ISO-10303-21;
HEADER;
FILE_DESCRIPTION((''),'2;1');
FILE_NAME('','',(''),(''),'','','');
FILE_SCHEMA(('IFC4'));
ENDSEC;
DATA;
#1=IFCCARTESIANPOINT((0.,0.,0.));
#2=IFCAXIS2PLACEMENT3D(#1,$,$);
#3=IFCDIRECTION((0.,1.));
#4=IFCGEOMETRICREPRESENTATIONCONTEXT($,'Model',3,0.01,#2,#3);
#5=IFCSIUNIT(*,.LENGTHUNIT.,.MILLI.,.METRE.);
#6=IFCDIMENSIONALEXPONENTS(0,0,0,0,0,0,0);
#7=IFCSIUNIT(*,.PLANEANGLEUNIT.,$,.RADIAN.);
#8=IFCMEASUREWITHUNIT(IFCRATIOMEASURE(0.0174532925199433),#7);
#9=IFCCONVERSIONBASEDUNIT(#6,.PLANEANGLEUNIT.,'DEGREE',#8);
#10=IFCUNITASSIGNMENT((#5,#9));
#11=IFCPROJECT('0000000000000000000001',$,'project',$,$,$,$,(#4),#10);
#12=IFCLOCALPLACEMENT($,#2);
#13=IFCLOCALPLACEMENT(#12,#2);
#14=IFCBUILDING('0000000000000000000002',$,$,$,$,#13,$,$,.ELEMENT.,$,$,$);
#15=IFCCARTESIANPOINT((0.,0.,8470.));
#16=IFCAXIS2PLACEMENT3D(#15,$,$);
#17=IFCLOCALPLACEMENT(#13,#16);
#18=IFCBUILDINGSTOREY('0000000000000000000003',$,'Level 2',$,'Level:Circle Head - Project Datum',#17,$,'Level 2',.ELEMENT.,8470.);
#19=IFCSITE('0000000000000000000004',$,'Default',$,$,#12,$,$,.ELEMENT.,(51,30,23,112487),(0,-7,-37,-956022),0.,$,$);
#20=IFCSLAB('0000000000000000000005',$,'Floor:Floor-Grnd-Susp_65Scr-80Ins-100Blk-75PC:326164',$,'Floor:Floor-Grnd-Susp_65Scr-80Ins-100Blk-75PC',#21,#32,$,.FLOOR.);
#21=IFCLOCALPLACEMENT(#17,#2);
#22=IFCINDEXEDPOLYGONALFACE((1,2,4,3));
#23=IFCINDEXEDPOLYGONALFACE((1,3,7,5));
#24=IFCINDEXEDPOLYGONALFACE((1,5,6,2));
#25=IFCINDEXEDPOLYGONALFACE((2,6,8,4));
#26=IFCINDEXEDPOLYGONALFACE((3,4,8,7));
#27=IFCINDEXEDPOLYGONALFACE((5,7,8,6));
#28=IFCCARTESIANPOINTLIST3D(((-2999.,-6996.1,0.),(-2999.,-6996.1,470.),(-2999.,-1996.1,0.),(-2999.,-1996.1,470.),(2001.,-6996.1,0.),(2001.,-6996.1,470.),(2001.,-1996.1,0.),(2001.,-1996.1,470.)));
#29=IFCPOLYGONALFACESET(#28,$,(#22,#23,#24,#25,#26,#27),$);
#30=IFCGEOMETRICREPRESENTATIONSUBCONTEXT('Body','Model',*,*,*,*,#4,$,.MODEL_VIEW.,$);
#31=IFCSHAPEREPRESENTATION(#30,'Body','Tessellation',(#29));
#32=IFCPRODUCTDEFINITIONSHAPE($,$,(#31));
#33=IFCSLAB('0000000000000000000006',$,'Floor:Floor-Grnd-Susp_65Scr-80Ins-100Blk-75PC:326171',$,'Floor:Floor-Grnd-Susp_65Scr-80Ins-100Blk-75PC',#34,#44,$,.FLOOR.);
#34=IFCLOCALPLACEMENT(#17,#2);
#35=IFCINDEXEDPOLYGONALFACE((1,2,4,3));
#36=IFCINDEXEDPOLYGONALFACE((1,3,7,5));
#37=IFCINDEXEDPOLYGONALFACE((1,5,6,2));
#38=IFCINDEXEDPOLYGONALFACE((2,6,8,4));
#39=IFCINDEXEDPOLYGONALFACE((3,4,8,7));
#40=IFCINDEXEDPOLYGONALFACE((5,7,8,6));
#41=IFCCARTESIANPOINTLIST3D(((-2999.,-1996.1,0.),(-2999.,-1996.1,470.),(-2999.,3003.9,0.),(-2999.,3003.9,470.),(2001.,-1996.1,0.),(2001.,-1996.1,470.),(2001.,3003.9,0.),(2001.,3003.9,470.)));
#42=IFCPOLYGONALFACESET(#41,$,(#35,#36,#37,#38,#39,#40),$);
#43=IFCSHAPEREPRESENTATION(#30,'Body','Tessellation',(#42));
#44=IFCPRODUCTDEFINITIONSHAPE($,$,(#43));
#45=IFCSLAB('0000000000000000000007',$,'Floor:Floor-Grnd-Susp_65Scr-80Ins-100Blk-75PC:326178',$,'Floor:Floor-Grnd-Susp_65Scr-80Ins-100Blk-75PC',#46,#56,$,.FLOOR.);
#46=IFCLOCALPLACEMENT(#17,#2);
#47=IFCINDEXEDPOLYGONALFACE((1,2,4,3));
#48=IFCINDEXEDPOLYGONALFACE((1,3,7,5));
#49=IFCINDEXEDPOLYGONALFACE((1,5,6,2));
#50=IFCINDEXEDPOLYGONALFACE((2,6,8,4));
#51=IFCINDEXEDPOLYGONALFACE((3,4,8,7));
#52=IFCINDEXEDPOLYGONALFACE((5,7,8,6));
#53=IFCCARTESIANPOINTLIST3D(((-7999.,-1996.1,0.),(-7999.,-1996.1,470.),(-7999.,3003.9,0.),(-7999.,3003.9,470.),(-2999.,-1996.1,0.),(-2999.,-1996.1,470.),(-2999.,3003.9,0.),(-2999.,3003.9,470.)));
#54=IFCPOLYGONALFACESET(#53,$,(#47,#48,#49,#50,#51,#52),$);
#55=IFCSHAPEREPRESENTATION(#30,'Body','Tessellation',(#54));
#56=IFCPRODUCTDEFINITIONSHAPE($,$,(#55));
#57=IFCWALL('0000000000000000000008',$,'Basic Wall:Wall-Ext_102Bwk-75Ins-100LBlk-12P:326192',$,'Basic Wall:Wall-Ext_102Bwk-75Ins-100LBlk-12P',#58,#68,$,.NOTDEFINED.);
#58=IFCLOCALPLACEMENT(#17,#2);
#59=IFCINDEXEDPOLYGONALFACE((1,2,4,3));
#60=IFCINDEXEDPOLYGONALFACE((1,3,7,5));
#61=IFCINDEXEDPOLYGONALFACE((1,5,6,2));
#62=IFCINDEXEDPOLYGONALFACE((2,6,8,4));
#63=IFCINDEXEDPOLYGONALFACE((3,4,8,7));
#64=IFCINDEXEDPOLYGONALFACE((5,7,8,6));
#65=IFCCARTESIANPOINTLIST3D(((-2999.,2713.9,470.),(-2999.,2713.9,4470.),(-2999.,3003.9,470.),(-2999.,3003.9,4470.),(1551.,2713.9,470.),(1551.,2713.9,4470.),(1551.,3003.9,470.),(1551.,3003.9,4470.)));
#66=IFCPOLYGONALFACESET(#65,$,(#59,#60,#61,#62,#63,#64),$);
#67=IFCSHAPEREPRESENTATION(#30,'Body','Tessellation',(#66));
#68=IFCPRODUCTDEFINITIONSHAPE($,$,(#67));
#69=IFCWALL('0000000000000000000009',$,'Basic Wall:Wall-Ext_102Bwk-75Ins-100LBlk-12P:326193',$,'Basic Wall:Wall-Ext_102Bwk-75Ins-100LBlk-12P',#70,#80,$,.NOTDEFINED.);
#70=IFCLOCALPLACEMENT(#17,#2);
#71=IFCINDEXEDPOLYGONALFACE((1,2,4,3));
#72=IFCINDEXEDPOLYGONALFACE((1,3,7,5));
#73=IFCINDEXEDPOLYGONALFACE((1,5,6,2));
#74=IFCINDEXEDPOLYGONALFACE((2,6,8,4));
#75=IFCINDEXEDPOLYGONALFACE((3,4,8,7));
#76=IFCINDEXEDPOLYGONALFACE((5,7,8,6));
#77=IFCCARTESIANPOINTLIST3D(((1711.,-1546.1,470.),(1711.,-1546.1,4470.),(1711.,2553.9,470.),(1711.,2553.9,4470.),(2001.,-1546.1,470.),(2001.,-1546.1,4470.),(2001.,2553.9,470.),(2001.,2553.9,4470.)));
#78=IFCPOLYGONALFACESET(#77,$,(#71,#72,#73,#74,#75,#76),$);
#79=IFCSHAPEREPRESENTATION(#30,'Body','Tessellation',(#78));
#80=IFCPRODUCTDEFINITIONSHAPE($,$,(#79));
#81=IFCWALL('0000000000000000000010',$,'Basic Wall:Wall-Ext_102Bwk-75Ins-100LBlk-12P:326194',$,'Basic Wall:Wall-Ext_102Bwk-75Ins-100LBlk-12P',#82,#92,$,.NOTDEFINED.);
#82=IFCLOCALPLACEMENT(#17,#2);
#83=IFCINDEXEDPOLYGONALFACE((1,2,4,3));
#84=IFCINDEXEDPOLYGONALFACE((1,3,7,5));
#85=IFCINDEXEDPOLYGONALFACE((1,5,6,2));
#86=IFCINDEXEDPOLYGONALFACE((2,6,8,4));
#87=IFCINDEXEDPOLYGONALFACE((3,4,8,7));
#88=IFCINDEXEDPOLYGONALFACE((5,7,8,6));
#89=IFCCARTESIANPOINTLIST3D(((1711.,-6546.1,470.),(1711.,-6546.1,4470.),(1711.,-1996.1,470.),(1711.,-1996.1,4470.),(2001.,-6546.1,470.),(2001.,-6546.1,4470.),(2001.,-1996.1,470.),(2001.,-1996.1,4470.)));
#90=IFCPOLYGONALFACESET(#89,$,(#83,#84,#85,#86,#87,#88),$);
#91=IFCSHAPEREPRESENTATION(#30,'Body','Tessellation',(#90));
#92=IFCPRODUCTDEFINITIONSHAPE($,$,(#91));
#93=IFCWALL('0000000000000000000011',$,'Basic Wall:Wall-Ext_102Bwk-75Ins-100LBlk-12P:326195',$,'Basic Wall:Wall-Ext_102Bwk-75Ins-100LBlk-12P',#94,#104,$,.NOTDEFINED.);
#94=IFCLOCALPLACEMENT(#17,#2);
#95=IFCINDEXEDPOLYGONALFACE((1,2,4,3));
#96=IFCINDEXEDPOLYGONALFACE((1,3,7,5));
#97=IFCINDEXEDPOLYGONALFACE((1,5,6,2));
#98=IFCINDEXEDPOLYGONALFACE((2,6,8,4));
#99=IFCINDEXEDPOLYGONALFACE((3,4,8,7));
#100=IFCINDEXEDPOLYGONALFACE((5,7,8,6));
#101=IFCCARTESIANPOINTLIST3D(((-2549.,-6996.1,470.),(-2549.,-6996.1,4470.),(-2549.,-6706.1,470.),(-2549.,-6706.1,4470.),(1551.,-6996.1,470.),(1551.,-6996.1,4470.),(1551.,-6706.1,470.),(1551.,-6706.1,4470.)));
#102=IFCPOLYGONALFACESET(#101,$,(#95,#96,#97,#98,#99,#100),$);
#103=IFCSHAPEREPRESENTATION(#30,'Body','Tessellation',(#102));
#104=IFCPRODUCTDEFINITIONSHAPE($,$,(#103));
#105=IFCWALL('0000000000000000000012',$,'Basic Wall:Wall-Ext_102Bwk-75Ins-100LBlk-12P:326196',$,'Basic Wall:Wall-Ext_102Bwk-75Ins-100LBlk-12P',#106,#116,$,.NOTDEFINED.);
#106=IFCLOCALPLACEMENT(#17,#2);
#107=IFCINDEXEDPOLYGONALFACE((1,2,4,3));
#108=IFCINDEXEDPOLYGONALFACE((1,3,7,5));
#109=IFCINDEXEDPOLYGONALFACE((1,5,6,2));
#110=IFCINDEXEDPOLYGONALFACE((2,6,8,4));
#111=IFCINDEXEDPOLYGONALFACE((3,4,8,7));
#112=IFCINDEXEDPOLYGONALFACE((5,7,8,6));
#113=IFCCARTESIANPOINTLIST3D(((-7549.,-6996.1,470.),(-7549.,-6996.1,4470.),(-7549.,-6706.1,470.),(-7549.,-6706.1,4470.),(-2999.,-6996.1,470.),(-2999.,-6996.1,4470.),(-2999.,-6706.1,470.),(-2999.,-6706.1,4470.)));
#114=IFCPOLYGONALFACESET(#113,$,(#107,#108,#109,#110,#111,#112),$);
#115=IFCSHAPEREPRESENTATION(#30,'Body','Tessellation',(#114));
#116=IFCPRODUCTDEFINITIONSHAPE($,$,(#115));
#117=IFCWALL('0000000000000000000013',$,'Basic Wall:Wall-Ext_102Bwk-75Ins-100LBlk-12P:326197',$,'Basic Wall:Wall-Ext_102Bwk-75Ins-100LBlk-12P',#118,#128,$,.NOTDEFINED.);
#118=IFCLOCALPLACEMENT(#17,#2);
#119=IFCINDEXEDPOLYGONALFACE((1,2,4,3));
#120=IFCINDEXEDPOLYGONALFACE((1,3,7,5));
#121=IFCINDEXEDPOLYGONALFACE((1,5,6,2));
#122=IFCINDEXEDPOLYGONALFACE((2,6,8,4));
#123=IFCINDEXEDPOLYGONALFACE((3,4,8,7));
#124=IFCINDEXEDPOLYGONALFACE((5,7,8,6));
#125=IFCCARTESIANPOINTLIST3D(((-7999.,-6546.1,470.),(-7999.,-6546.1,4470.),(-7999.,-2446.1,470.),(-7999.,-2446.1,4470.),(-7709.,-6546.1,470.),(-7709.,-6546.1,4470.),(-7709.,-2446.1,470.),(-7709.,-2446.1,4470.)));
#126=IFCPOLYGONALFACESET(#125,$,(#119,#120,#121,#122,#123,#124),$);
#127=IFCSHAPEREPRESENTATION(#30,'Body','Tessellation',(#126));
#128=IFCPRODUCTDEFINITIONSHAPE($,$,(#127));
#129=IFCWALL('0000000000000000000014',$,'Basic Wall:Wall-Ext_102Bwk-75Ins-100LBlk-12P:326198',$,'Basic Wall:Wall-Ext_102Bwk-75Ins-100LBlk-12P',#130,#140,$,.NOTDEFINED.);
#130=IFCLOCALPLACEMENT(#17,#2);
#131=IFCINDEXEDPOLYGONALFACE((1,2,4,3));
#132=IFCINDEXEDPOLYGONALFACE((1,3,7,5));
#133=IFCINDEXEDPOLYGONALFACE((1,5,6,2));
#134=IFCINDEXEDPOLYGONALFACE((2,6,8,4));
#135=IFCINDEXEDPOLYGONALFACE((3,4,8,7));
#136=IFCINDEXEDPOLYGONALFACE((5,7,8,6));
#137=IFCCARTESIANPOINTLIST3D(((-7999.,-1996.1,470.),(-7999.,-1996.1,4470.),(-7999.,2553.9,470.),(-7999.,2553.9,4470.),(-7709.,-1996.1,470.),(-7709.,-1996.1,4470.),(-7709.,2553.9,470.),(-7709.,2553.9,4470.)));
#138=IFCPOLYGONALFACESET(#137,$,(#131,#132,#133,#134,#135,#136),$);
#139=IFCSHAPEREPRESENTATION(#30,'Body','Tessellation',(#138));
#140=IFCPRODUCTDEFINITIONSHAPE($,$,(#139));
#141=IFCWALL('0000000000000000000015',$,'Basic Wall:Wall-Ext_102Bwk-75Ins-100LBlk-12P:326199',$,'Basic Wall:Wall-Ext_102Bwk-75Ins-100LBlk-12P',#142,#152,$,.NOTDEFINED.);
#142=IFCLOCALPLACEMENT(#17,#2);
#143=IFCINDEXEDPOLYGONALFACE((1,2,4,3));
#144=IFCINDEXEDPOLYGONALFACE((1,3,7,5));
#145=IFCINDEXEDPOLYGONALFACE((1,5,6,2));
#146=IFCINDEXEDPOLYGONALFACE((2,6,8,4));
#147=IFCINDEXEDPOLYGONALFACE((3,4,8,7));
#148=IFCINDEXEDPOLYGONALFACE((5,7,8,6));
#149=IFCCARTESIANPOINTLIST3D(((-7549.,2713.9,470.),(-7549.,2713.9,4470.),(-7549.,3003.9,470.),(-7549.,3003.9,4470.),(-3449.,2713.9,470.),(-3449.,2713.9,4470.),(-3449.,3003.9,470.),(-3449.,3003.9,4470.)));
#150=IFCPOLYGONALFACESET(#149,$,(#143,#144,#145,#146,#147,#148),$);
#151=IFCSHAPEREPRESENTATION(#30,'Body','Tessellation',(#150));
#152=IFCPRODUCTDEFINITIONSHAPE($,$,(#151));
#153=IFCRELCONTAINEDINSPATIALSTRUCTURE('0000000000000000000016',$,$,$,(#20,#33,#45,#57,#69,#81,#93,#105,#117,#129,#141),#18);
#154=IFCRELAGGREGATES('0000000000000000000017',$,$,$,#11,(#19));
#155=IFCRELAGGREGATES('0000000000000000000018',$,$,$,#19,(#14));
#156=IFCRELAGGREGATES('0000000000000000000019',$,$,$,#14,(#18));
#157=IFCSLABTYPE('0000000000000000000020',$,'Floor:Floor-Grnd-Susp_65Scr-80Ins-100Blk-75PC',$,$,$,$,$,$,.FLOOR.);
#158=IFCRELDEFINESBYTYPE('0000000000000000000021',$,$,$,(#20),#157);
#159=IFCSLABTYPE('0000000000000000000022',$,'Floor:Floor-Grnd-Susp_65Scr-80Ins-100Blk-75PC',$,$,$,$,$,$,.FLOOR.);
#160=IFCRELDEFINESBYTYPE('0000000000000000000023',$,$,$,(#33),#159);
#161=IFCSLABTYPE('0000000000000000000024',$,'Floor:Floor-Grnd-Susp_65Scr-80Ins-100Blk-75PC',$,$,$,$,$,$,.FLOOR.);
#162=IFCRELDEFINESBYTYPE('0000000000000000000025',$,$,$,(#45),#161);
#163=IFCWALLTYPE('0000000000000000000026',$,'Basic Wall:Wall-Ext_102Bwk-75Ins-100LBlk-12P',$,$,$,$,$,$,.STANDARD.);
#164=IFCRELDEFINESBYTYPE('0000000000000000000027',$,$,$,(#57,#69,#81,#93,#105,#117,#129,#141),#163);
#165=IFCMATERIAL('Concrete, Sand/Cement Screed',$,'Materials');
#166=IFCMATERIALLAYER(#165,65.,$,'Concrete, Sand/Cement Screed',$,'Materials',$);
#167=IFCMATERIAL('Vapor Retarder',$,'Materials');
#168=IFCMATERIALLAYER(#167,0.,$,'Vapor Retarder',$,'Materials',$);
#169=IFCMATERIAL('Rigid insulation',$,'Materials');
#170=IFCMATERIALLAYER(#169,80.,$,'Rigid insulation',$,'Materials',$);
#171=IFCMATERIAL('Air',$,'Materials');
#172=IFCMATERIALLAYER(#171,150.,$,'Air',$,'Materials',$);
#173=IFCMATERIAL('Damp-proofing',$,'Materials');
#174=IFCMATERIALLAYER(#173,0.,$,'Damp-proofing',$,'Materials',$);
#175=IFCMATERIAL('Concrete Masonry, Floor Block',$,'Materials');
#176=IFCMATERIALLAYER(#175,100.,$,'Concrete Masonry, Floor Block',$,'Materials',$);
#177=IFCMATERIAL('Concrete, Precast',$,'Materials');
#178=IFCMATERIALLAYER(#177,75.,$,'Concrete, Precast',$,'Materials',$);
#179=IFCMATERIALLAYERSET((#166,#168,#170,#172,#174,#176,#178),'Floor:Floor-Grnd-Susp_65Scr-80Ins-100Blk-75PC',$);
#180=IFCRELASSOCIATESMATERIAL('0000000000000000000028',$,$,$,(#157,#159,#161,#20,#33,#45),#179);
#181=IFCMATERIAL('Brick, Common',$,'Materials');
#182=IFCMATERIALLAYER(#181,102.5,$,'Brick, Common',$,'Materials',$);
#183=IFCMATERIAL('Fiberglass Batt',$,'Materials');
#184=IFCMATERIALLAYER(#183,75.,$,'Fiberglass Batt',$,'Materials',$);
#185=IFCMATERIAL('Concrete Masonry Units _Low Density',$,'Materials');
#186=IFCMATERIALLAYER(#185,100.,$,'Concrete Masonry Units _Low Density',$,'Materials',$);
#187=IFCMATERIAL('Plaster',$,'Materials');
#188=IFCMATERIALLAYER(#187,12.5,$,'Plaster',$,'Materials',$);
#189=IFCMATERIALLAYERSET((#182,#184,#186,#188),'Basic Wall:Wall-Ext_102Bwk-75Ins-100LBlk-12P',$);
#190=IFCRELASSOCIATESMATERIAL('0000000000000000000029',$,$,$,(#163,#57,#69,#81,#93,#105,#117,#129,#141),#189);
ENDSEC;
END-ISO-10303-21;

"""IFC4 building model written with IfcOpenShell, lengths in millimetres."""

from ifc_helpers import new_model, entity, si_unit, converted_unit, direction, frame, frame_2d, origin, origin_2d_with_axis, place, context, subcontext, project, spatial, rectangle, extrude, material, layer, layer_set, layer_usage, type_object, element, save


model = new_model("IFC4")

# Units and contexts
model_context = context("Model", 3, precision=0.01, world=origin(), true_north=direction((0.0, 1.0)))
body_context = subcontext(model_context, "Body", "Model", "MODEL_VIEW")
ifc_project = project(units=[si_unit("LENGTHUNIT", "METRE", prefix="MILLI"), converted_unit("PLANEANGLEUNIT", "DEGREE", entity("IfcRatioMeasure", 0.0174532925199433), si_unit("PLANEANGLEUNIT", "RADIAN"), dimensions=[0, 0, 0, 0, 0, 0, 0])], contexts=[model_context])

# Site, building, storey
site_placement = place(None, origin())
site = spatial("IfcSite", under=ifc_project, at=site_placement, Name="Default", CompositionType="ELEMENT", RefLatitude=(51, 30, 23, 112487), RefLongitude=(0, -7, -37, -956022), RefElevation=0.0)
building_placement = place(site_placement, origin())
building = spatial("IfcBuilding", under=site, at=building_placement, CompositionType="ELEMENT")
storey_placement = place(building_placement, frame((0.0, 0.0, 8470.0)))
storey = spatial("IfcBuildingStorey", under=building, at=storey_placement, Name="Level 2", ObjectType="Level:Circle Head - Project Datum", LongName="Level 2", CompositionType="ELEMENT", Elevation=8470.0)

# Slabs
ifc_material_1 = material(Name="Concrete, Sand/Cement Screed", Category="Materials")
ifc_layer_1 = layer(ifc_material_1, 65.0, Name="Concrete, Sand/Cement Screed", Category="Materials")
ifc_material_2 = material(Name="Vapor Retarder", Category="Materials")
ifc_layer_2 = layer(ifc_material_2, 0.0, Name="Vapor Retarder", Category="Materials")
ifc_material_3 = material(Name="Rigid insulation", Category="Materials")
ifc_layer_3 = layer(ifc_material_3, 80.0, Name="Rigid insulation", Category="Materials")
ifc_material_4 = material(Name="Air", Category="Materials")
ifc_layer_4 = layer(ifc_material_4, 150.0, Name="Air", Category="Materials")
ifc_material_5 = material(Name="Damp-proofing", Category="Materials")
ifc_layer_5 = layer(ifc_material_5, 0.0, Name="Damp-proofing", Category="Materials")
ifc_material_6 = material(Name="Concrete Masonry, Floor Block", Category="Materials")
ifc_layer_6 = layer(ifc_material_6, 100.0, Name="Concrete Masonry, Floor Block", Category="Materials")
ifc_material_7 = material(Name="Concrete, Precast", Category="Materials")
ifc_layer_7 = layer(ifc_material_7, 75.0, Name="Concrete, Precast", Category="Materials")
ifc_layer_set_1 = layer_set([ifc_layer_1, ifc_layer_2, ifc_layer_3, ifc_layer_4, ifc_layer_5, ifc_layer_6, ifc_layer_7], Name="Floor:Floor-Grnd-Susp_65Scr-80Ins-100Blk-75PC")
ifc_layer_usage_1 = layer_usage(ifc_layer_set_1, "AXIS3", "POSITIVE", 0.0)
slab_type_1 = type_object("IfcSlabType", Name="Floor:Floor-Grnd-Susp_65Scr-80Ins-100Blk-75PC", PredefinedType="FLOOR", material=ifc_layer_set_1)
slab_1_placement = place(storey_placement, origin())
element("IfcSlab", 1, at=slab_1_placement, inside=storey, type_object=slab_type_1, material=ifc_layer_usage_1, Name="Floor:Floor-Grnd-Susp_65Scr-80Ins-100Blk-75PC:326164", ObjectType="Floor:Floor-Grnd-Susp_65Scr-80Ins-100Blk-75PC", PredefinedType="FLOOR", context=body_context, shape_type="SweptSolid", body=[
    extrude(rectangle(XDim=5000.0, YDim=5000.0, at=frame_2d((0.0, 0.0), x_axis=(1.0, 0.0))), frame((-499.0, -4496.1, 470.0), z_axis=(0.0, 0.0, -1.0), x_axis=(0.0, 1.0, 0.0)), (0.0, 0.0, 1.0), 470.0),
])
ifc_layer_usage_2 = layer_usage(ifc_layer_set_1, "AXIS3", "POSITIVE", 0.0)
slab_type_2 = type_object("IfcSlabType", Name="Floor:Floor-Grnd-Susp_65Scr-80Ins-100Blk-75PC", PredefinedType="FLOOR", material=ifc_layer_set_1)
slab_2_placement = place(storey_placement, origin())
element("IfcSlab", 2, at=slab_2_placement, inside=storey, type_object=slab_type_2, material=ifc_layer_usage_2, Name="Floor:Floor-Grnd-Susp_65Scr-80Ins-100Blk-75PC:326171", ObjectType="Floor:Floor-Grnd-Susp_65Scr-80Ins-100Blk-75PC", PredefinedType="FLOOR", context=body_context, shape_type="SweptSolid", body=[
    extrude(rectangle(XDim=5000.0, YDim=5000.0, at=origin_2d_with_axis()), frame((-499.0, 503.9, 470.0), z_axis=(0.0, 0.0, -1.0), x_axis=(0.0, 1.0, 0.0)), (0.0, 0.0, 1.0), 470.0),
])
ifc_layer_usage_3 = layer_usage(ifc_layer_set_1, "AXIS3", "POSITIVE", 0.0)
slab_type_3 = type_object("IfcSlabType", Name="Floor:Floor-Grnd-Susp_65Scr-80Ins-100Blk-75PC", PredefinedType="FLOOR", material=ifc_layer_set_1)
slab_3_placement = place(storey_placement, origin())
element("IfcSlab", 3, at=slab_3_placement, inside=storey, type_object=slab_type_3, material=ifc_layer_usage_3, Name="Floor:Floor-Grnd-Susp_65Scr-80Ins-100Blk-75PC:326178", ObjectType="Floor:Floor-Grnd-Susp_65Scr-80Ins-100Blk-75PC", PredefinedType="FLOOR", context=body_context, shape_type="SweptSolid", body=[
    extrude(rectangle(XDim=5000.0, YDim=5000.0, at=origin_2d_with_axis()), frame((-5499.0, 503.9, 470.0), z_axis=(0.0, 0.0, -1.0), x_axis=(0.0, 1.0, 0.0)), (0.0, 0.0, 1.0), 470.0),
])

# Walls
ifc_material_8 = material(Name="Brick, Common", Category="Materials")
ifc_layer_8 = layer(ifc_material_8, 102.5, Name="Brick, Common", Category="Materials")
ifc_material_9 = material(Name="Fiberglass Batt", Category="Materials")
ifc_layer_9 = layer(ifc_material_9, 75.0, Name="Fiberglass Batt", Category="Materials")
ifc_material_10 = material(Name="Concrete Masonry Units _Low Density", Category="Materials")
ifc_layer_10 = layer(ifc_material_10, 100.0, Name="Concrete Masonry Units _Low Density", Category="Materials")
ifc_material_11 = material(Name="Plaster", Category="Materials")
ifc_layer_11 = layer(ifc_material_11, 12.5, Name="Plaster", Category="Materials")
ifc_layer_set_2 = layer_set([ifc_layer_8, ifc_layer_9, ifc_layer_10, ifc_layer_11], Name="Basic Wall:Wall-Ext_102Bwk-75Ins-100LBlk-12P")
ifc_layer_usage_4 = layer_usage(ifc_layer_set_2, "AXIS2", "NEGATIVE", 145.0)
wall_type = type_object("IfcWallType", Name="Basic Wall:Wall-Ext_102Bwk-75Ins-100LBlk-12P", PredefinedType="STANDARD", material=ifc_layer_set_2)
wall_1_placement = place(storey_placement, frame((-2999.0, 2858.9, 470.0)))
element("IfcWall", 4, at=wall_1_placement, inside=storey, type_object=wall_type, material=ifc_layer_usage_4, Name="Basic Wall:Wall-Ext_102Bwk-75Ins-100LBlk-12P:326192", ObjectType="Basic Wall:Wall-Ext_102Bwk-75Ins-100LBlk-12P", PredefinedType="NOTDEFINED", context=body_context, shape_type="SweptSolid", body=[
    extrude(rectangle(XDim=4550.0, YDim=290.0, at=frame_2d((2275.0, 0.0), x_axis=(-1.0, 0.0))), origin(), (0.0, 0.0, 1.0), 4000.0),
])
ifc_layer_usage_5 = layer_usage(ifc_layer_set_2, "AXIS2", "NEGATIVE", 145.0)
wall_2_placement = place(storey_placement, frame((1856.0, 2553.9, 470.0), z_axis=(0.0, 0.0, 1.0), x_axis=(0.0, -1.0, 0.0)))
element("IfcWall", 5, at=wall_2_placement, inside=storey, type_object=wall_type, material=ifc_layer_usage_5, Name="Basic Wall:Wall-Ext_102Bwk-75Ins-100LBlk-12P:326193", ObjectType="Basic Wall:Wall-Ext_102Bwk-75Ins-100LBlk-12P", PredefinedType="NOTDEFINED", context=body_context, shape_type="SweptSolid", body=[
    extrude(rectangle(XDim=4100.0, YDim=290.0, at=frame_2d((2050.0, 0.0), x_axis=(-1.0, 0.0))), origin(), (0.0, 0.0, 1.0), 4000.0),
])
ifc_layer_usage_6 = layer_usage(ifc_layer_set_2, "AXIS2", "NEGATIVE", 145.0)
wall_3_placement = place(storey_placement, frame((1856.0, -1996.1, 470.0), z_axis=(0.0, 0.0, 1.0), x_axis=(0.0, -1.0, 0.0)))
element("IfcWall", 6, at=wall_3_placement, inside=storey, type_object=wall_type, material=ifc_layer_usage_6, Name="Basic Wall:Wall-Ext_102Bwk-75Ins-100LBlk-12P:326194", ObjectType="Basic Wall:Wall-Ext_102Bwk-75Ins-100LBlk-12P", PredefinedType="NOTDEFINED", context=body_context, shape_type="SweptSolid", body=[
    extrude(rectangle(XDim=4550.0, YDim=290.0, at=frame_2d((2275.0, 0.0), x_axis=(-1.0, 0.0))), origin(), (0.0, 0.0, 1.0), 4000.0),
])
ifc_layer_usage_7 = layer_usage(ifc_layer_set_2, "AXIS2", "NEGATIVE", 145.0)
wall_4_placement = place(storey_placement, frame((1551.0, -6851.1, 470.0), z_axis=(0.0, 0.0, 1.0), x_axis=(-1.0, 0.0, 0.0)))
element("IfcWall", 7, at=wall_4_placement, inside=storey, type_object=wall_type, material=ifc_layer_usage_7, Name="Basic Wall:Wall-Ext_102Bwk-75Ins-100LBlk-12P:326195", ObjectType="Basic Wall:Wall-Ext_102Bwk-75Ins-100LBlk-12P", PredefinedType="NOTDEFINED", context=body_context, shape_type="SweptSolid", body=[
    extrude(rectangle(XDim=4100.0, YDim=290.0, at=frame_2d((2050.0, 0.0), x_axis=(-1.0, 0.0))), origin(), (0.0, 0.0, 1.0), 4000.0),
])
ifc_layer_usage_8 = layer_usage(ifc_layer_set_2, "AXIS2", "NEGATIVE", 145.0)
wall_5_placement = place(storey_placement, frame((-2999.0, -6851.1, 470.0), z_axis=(0.0, 0.0, 1.0), x_axis=(-1.0, 0.0, 0.0)))
element("IfcWall", 8, at=wall_5_placement, inside=storey, type_object=wall_type, material=ifc_layer_usage_8, Name="Basic Wall:Wall-Ext_102Bwk-75Ins-100LBlk-12P:326196", ObjectType="Basic Wall:Wall-Ext_102Bwk-75Ins-100LBlk-12P", PredefinedType="NOTDEFINED", context=body_context, shape_type="SweptSolid", body=[
    extrude(rectangle(XDim=4550.0, YDim=290.0, at=frame_2d((2275.0, 0.0), x_axis=(-1.0, 0.0))), origin(), (0.0, 0.0, 1.0), 4000.0),
])
ifc_layer_usage_9 = layer_usage(ifc_layer_set_2, "AXIS2", "NEGATIVE", 145.0)
wall_6_placement = place(storey_placement, frame((-7854.0, -6546.1, 470.0), z_axis=(0.0, 0.0, 1.0), x_axis=(0.0, 1.0, 0.0)))
element("IfcWall", 9, at=wall_6_placement, inside=storey, type_object=wall_type, material=ifc_layer_usage_9, Name="Basic Wall:Wall-Ext_102Bwk-75Ins-100LBlk-12P:326197", ObjectType="Basic Wall:Wall-Ext_102Bwk-75Ins-100LBlk-12P", PredefinedType="NOTDEFINED", context=body_context, shape_type="SweptSolid", body=[
    extrude(rectangle(XDim=4100.0, YDim=290.0, at=frame_2d((2050.0, 0.0), x_axis=(-1.0, 0.0))), origin(), (0.0, 0.0, 1.0), 4000.0),
])
ifc_layer_usage_10 = layer_usage(ifc_layer_set_2, "AXIS2", "NEGATIVE", 145.0)
wall_7_placement = place(storey_placement, frame((-7854.0, -1996.1, 470.0), z_axis=(0.0, 0.0, 1.0), x_axis=(0.0, 1.0, 0.0)))
element("IfcWall", 10, at=wall_7_placement, inside=storey, type_object=wall_type, material=ifc_layer_usage_10, Name="Basic Wall:Wall-Ext_102Bwk-75Ins-100LBlk-12P:326198", ObjectType="Basic Wall:Wall-Ext_102Bwk-75Ins-100LBlk-12P", PredefinedType="NOTDEFINED", context=body_context, shape_type="SweptSolid", body=[
    extrude(rectangle(XDim=4550.0, YDim=290.0, at=frame_2d((2275.0, 0.0), x_axis=(-1.0, 0.0))), origin(), (0.0, 0.0, 1.0), 4000.0),
])
ifc_layer_usage_11 = layer_usage(ifc_layer_set_2, "AXIS2", "NEGATIVE", 145.0)
wall_8_placement = place(storey_placement, frame((-7549.0, 2858.9, 470.0)))
element("IfcWall", 11, at=wall_8_placement, inside=storey, type_object=wall_type, material=ifc_layer_usage_11, Name="Basic Wall:Wall-Ext_102Bwk-75Ins-100LBlk-12P:326199", ObjectType="Basic Wall:Wall-Ext_102Bwk-75Ins-100LBlk-12P", PredefinedType="NOTDEFINED", context=body_context, shape_type="SweptSolid", body=[
    extrude(rectangle(XDim=4100.0, YDim=290.0, at=frame_2d((2050.0, 0.0), x_axis=(-1.0, 0.0))), origin(), (0.0, 0.0, 1.0), 4000.0),
])

save(model, "model.ifc")
